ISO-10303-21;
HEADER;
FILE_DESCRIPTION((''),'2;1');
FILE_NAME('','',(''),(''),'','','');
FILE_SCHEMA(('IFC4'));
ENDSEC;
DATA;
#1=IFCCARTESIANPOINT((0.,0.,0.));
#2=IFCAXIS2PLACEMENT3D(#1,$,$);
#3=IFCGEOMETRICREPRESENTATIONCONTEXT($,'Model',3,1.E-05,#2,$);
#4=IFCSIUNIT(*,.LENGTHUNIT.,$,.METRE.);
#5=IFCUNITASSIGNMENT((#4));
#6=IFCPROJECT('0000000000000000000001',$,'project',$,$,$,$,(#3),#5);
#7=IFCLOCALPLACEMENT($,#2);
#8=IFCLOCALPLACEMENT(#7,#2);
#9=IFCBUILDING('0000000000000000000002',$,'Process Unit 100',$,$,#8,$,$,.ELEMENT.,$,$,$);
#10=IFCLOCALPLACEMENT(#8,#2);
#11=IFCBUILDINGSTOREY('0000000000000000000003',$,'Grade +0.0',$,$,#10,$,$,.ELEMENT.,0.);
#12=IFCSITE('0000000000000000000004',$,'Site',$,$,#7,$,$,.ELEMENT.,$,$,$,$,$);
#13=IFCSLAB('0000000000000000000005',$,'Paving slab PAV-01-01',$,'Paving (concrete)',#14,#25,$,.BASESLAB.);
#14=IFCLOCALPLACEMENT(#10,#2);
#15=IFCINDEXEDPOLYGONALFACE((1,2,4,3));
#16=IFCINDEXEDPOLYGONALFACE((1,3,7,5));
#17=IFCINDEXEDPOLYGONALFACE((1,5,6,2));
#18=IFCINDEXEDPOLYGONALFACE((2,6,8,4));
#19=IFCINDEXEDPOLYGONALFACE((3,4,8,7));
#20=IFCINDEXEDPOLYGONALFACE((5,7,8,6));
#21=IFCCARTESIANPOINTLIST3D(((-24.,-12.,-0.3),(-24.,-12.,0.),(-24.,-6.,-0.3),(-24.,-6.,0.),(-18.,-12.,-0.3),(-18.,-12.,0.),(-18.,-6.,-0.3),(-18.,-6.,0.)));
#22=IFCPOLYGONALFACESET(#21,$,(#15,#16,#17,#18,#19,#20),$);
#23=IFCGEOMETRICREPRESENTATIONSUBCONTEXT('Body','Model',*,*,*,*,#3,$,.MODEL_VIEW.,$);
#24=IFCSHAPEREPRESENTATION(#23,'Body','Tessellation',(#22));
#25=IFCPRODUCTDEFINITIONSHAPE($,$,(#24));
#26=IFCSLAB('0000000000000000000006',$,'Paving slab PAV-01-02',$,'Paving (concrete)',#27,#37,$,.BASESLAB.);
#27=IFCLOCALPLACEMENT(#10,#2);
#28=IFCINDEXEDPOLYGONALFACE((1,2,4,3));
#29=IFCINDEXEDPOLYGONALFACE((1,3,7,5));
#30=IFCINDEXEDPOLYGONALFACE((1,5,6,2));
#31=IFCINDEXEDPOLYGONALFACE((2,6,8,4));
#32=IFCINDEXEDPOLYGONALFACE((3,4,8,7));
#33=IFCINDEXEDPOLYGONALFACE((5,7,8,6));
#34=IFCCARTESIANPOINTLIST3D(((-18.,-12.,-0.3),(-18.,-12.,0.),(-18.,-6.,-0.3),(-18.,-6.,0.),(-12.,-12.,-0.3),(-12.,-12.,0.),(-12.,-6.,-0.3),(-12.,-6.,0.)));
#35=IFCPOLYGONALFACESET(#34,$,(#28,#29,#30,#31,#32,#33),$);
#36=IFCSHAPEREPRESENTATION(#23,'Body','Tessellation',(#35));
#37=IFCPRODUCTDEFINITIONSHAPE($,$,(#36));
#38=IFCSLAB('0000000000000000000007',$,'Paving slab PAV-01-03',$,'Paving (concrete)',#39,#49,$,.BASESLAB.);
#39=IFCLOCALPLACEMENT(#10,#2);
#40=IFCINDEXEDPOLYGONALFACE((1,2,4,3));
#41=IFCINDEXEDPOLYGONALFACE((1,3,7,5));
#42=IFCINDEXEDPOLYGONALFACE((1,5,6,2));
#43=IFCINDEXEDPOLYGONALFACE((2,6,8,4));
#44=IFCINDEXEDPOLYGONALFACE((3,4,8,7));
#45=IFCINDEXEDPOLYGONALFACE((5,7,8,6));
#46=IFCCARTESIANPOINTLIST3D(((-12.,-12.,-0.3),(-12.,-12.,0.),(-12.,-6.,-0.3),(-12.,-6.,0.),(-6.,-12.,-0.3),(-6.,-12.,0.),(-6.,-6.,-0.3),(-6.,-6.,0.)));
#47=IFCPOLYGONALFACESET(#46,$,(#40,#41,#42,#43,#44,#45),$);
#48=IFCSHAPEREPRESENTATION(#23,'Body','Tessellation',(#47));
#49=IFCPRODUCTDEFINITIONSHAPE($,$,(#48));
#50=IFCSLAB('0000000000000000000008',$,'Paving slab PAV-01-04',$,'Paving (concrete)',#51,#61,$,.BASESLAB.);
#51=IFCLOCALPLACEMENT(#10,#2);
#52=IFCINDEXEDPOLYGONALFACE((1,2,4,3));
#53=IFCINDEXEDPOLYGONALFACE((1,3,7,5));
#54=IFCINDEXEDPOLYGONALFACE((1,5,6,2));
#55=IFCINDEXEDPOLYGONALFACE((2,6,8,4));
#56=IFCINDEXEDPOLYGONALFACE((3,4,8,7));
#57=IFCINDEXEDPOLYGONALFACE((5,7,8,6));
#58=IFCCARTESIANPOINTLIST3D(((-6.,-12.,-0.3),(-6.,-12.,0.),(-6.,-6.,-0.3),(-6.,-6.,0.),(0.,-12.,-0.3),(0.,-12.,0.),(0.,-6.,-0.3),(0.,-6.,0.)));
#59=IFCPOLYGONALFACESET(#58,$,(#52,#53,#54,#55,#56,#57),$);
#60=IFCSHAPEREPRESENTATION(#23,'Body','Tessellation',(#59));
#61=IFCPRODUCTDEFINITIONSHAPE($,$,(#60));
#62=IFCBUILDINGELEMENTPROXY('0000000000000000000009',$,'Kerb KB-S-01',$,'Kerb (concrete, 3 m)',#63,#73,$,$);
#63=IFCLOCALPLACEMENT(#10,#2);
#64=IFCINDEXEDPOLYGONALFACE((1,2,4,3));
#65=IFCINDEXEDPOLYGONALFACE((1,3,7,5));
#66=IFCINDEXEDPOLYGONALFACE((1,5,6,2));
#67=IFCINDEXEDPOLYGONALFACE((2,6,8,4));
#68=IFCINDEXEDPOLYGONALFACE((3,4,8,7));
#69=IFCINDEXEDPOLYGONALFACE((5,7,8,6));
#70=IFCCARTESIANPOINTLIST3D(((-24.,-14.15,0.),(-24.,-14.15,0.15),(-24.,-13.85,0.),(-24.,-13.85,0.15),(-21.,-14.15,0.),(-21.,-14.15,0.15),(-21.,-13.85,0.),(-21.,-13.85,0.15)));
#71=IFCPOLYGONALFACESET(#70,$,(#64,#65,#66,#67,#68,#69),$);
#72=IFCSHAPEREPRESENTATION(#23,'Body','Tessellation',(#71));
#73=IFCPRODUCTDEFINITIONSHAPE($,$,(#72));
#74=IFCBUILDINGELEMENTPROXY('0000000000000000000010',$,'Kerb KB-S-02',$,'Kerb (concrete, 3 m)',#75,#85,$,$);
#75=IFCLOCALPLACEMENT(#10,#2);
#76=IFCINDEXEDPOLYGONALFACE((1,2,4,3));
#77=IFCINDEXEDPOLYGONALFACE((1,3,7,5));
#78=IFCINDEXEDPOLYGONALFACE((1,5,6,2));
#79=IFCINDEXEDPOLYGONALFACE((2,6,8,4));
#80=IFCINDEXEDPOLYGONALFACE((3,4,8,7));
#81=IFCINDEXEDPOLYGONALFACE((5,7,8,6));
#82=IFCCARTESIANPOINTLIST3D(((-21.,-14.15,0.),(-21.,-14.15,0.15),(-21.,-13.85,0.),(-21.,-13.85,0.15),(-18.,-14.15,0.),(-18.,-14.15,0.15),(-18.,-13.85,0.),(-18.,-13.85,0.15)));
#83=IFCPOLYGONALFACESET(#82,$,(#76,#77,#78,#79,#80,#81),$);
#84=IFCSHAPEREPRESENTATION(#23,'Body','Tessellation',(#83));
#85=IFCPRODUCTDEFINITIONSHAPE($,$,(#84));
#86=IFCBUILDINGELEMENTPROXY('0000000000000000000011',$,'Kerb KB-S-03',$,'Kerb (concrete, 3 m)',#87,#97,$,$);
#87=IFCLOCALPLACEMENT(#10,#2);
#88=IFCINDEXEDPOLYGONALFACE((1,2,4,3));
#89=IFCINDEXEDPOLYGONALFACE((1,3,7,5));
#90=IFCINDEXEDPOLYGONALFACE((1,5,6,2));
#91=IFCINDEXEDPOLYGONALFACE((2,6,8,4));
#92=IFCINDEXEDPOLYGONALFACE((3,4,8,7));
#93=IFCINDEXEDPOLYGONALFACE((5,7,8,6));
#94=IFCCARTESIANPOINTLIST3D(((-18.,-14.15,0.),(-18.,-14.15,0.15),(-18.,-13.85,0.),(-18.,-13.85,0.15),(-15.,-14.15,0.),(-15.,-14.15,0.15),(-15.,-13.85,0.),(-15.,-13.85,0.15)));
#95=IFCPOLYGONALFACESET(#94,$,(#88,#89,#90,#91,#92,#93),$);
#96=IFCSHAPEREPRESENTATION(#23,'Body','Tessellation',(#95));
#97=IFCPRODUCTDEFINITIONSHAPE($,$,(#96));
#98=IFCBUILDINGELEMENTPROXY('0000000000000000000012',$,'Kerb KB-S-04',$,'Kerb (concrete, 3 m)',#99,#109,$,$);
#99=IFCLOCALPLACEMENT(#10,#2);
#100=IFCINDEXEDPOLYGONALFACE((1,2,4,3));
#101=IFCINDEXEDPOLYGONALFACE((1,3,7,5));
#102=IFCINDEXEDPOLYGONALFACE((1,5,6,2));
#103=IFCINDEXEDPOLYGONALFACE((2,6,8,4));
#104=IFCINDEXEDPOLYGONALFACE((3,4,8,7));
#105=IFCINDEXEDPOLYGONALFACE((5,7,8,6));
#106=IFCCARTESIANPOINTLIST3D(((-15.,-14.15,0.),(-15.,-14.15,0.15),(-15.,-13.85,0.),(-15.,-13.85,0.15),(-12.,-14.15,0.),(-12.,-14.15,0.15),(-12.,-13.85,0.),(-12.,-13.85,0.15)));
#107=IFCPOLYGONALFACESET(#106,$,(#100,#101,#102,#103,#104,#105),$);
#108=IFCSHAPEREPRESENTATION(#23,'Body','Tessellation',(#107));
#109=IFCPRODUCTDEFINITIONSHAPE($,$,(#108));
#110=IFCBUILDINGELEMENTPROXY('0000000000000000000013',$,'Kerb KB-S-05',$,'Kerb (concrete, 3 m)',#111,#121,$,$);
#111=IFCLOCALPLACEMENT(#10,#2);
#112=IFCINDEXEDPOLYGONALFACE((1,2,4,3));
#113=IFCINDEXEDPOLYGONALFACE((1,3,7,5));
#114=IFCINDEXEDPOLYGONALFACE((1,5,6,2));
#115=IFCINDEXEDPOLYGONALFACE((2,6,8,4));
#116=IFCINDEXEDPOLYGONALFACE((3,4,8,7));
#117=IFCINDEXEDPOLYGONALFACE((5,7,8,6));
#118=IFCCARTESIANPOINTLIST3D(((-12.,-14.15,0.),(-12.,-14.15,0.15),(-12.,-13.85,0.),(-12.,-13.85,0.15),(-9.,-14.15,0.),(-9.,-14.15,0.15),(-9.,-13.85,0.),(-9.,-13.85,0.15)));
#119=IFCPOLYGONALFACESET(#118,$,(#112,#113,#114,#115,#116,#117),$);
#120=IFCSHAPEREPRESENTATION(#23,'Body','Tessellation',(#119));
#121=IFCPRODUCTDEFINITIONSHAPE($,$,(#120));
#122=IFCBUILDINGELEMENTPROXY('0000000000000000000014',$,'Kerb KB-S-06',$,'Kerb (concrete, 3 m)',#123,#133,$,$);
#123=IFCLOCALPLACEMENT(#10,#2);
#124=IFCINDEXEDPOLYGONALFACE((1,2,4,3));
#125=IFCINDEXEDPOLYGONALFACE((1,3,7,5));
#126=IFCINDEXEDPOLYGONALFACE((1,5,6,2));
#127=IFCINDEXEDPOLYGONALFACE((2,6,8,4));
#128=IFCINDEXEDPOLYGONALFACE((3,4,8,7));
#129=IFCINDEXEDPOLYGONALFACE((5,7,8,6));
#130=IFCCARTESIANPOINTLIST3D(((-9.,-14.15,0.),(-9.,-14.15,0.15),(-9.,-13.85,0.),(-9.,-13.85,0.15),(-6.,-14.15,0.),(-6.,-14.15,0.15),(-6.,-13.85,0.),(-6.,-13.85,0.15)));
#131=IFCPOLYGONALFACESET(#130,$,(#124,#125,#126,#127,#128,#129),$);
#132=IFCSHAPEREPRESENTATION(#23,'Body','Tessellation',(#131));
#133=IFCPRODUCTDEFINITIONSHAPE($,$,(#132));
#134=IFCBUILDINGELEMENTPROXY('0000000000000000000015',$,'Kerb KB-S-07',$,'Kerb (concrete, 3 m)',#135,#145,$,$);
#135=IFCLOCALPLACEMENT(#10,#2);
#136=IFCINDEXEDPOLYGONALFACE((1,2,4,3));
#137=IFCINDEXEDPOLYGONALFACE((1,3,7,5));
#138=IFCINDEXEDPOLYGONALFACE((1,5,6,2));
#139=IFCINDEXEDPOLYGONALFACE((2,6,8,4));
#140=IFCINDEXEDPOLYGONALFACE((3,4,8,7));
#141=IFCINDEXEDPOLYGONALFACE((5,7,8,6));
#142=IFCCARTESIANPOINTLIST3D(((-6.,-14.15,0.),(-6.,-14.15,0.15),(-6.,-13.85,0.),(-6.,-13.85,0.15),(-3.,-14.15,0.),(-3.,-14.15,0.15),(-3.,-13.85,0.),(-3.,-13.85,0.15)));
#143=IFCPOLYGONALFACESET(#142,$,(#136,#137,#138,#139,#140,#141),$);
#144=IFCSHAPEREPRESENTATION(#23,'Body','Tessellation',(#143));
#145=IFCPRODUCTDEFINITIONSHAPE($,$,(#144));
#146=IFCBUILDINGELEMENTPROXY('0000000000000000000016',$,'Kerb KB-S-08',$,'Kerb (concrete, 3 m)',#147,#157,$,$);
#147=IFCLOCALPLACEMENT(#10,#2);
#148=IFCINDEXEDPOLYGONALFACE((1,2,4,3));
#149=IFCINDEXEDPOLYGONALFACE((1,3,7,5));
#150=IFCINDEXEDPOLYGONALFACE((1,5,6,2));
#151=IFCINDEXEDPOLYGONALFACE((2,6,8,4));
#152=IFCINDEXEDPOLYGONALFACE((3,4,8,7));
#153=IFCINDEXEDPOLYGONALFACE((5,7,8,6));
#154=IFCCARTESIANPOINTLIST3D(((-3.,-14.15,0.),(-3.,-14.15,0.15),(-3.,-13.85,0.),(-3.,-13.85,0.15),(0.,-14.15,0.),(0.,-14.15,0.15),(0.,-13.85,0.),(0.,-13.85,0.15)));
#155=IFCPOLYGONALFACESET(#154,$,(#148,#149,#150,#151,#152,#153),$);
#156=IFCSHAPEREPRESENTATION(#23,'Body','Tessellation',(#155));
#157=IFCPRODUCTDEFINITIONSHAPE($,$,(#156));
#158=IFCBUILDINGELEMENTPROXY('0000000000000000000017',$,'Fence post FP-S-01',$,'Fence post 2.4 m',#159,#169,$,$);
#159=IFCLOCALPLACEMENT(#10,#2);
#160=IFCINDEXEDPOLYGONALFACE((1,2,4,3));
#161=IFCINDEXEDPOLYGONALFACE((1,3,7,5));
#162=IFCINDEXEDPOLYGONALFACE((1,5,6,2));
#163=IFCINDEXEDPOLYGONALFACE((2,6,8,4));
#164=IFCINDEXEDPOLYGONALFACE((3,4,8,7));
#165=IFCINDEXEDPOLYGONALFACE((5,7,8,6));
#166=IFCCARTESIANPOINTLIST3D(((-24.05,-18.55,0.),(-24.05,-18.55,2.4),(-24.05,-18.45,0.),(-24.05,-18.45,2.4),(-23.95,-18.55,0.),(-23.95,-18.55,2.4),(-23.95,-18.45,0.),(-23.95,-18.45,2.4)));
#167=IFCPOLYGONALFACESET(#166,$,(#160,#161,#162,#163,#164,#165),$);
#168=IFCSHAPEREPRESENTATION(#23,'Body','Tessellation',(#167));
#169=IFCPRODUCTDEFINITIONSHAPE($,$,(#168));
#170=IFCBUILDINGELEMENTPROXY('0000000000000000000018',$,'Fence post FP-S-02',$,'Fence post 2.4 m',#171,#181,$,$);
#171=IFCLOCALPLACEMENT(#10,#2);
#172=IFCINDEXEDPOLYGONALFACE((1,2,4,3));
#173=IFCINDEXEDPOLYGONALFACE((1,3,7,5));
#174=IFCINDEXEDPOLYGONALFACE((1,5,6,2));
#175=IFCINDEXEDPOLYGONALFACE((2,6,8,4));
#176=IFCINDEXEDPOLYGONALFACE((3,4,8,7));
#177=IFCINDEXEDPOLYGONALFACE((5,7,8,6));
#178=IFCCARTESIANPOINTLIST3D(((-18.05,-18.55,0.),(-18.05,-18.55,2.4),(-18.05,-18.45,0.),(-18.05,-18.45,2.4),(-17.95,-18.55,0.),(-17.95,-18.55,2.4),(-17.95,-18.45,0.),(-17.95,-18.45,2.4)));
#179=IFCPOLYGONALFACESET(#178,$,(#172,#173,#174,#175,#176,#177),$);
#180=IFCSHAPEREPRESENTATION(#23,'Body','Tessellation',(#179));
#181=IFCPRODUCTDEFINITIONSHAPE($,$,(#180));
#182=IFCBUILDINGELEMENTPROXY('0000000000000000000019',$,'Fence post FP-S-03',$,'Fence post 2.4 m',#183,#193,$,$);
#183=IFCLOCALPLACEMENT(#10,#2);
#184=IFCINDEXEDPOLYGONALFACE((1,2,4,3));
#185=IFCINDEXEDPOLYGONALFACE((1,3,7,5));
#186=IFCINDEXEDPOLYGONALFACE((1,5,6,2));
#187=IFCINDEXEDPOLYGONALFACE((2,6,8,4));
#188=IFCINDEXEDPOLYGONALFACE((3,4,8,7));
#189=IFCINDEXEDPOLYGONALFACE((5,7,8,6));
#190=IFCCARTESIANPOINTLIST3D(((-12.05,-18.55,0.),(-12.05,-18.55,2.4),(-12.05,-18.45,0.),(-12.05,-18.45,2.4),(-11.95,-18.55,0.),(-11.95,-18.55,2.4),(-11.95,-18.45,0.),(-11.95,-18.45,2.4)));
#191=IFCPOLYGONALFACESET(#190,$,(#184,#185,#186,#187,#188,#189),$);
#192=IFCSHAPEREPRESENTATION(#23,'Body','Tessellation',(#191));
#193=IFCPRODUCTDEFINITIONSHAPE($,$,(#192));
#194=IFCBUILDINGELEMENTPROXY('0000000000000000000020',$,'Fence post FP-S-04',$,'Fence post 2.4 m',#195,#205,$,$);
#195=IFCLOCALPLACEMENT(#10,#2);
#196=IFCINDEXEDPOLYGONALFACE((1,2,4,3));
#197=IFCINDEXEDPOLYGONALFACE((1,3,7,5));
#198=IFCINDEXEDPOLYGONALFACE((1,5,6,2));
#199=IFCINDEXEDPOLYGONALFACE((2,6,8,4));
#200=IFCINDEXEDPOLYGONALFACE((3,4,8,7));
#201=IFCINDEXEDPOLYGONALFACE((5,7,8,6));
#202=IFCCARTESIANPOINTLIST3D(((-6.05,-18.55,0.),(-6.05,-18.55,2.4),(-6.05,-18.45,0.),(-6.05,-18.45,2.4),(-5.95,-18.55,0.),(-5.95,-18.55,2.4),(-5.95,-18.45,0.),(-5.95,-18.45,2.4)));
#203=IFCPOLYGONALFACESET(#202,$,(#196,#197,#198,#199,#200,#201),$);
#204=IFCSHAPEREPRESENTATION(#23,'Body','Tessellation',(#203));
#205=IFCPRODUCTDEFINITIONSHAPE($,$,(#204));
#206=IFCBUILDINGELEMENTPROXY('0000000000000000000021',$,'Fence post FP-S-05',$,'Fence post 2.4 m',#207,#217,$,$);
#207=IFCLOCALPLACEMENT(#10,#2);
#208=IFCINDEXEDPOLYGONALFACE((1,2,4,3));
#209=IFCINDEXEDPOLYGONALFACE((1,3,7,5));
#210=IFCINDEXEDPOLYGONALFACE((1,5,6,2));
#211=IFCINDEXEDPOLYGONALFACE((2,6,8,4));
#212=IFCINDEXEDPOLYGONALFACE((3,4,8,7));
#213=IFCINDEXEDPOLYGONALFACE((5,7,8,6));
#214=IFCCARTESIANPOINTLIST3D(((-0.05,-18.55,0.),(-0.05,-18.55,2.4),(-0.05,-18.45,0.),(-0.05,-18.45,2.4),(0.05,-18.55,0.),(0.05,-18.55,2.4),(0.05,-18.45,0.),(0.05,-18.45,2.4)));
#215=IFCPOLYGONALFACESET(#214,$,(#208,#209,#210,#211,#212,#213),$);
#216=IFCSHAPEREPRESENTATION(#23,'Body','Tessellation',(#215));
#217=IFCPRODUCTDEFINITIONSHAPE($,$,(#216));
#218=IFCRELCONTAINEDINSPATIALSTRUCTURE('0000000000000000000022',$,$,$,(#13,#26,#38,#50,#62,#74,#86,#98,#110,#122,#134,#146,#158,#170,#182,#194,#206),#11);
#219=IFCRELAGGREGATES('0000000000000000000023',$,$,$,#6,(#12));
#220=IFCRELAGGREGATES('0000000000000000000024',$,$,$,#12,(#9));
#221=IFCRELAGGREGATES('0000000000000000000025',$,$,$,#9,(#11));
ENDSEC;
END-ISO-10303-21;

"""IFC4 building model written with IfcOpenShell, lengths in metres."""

from ifc_helpers import new_model, si_unit, frame, origin, place, context, subcontext, project, spatial, rectangle, extrude, element, save


model = new_model("IFC4")

# Units and contexts
model_context = context("Model", 3, precision=1e-05, world=origin())
body_context = subcontext(model_context, "Body", "Model", "MODEL_VIEW")
ifc_project = project(units=[si_unit("LENGTHUNIT", "METRE")], contexts=[model_context])

# Site, building, storey
site_placement = place(None, origin())
site = spatial("IfcSite", under=ifc_project, at=site_placement, Name="Site", CompositionType="ELEMENT")
building_placement = place(site_placement, origin())
building = spatial("IfcBuilding", under=site, at=building_placement, Name="Process Unit 100", CompositionType="ELEMENT")
storey_placement = place(building_placement, origin())
storey = spatial("IfcBuildingStorey", under=building, at=storey_placement, Name="Grade +0.0", CompositionType="ELEMENT", Elevation=0.0)

# Slabs
for number, where, z_axis, x_axis, name in (
    (1, (-21.0, -9.0, -0.3), (0.0, 0.0, 1.0), (1.0, 0.0, 0.0), "Paving slab PAV-01-01"),
    (2, (-15.0, -9.0, -0.3), (0.0, 0.0, 1.0), (1.0, 0.0, 0.0), "Paving slab PAV-01-02"),
    (3, (-9.0, -9.0, -0.3), (0.0, 0.0, 1.0), (1.0, 0.0, 0.0), "Paving slab PAV-01-03"),
    (4, (-3.0, -9.0, -0.3), (0.0, 0.0, 1.0), (1.0, 0.0, 0.0), "Paving slab PAV-01-04"),
):
    element("IfcSlab", number, at=place(storey_placement, frame(where, z_axis=z_axis, x_axis=x_axis)), inside=storey, Name=name, ObjectType="Paving (concrete)", PredefinedType="BASESLAB", context=body_context, shape_type="SweptSolid", body=[
        extrude(rectangle(XDim=6.0, YDim=6.0), origin(), (0.0, 0.0, 1.0), 0.3),
    ])

# Building element proxies
for number, where, z_axis, x_axis, name in (
    (5, (-22.5, -14.0, 0.0), (0.0, 0.0, 1.0), (1.0, 0.0, 0.0), "Kerb KB-S-01"),
    (6, (-19.5, -14.0, 0.0), (0.0, 0.0, 1.0), (1.0, 0.0, 0.0), "Kerb KB-S-02"),
    (7, (-16.5, -14.0, 0.0), (0.0, 0.0, 1.0), (1.0, 0.0, 0.0), "Kerb KB-S-03"),
    (8, (-13.5, -14.0, 0.0), (0.0, 0.0, 1.0), (1.0, 0.0, 0.0), "Kerb KB-S-04"),
    (9, (-10.5, -14.0, 0.0), (0.0, 0.0, 1.0), (1.0, 0.0, 0.0), "Kerb KB-S-05"),
    (10, (-7.5, -14.0, 0.0), (0.0, 0.0, 1.0), (1.0, 0.0, 0.0), "Kerb KB-S-06"),
    (11, (-4.5, -14.0, 0.0), (0.0, 0.0, 1.0), (1.0, 0.0, 0.0), "Kerb KB-S-07"),
    (12, (-1.5, -14.0, 0.0), (0.0, 0.0, 1.0), (1.0, 0.0, 0.0), "Kerb KB-S-08"),
):
    element("IfcBuildingElementProxy", number, at=place(storey_placement, frame(where, z_axis=z_axis, x_axis=x_axis)), inside=storey, Name=name, ObjectType="Kerb (concrete, 3 m)", context=body_context, shape_type="SweptSolid", body=[
        extrude(rectangle(XDim=3.0, YDim=0.3), origin(), (0.0, 0.0, 1.0), 0.15),
    ])
for number, where, z_axis, x_axis, name in (
    (13, (-24.0, -18.5, 0.0), (0.0, 0.0, 1.0), (1.0, 0.0, 0.0), "Fence post FP-S-01"),
    (14, (-18.0, -18.5, 0.0), (0.0, 0.0, 1.0), (1.0, 0.0, 0.0), "Fence post FP-S-02"),
    (15, (-12.0, -18.5, 0.0), (0.0, 0.0, 1.0), (1.0, 0.0, 0.0), "Fence post FP-S-03"),
    (16, (-6.0, -18.5, 0.0), (0.0, 0.0, 1.0), (1.0, 0.0, 0.0), "Fence post FP-S-04"),
    (17, (0.0, -18.5, 0.0), (0.0, 0.0, 1.0), (1.0, 0.0, 0.0), "Fence post FP-S-05"),
):
    element("IfcBuildingElementProxy", number, at=place(storey_placement, frame(where, z_axis=z_axis, x_axis=x_axis)), inside=storey, Name=name, ObjectType="Fence post 2.4 m", context=body_context, shape_type="SweptSolid", body=[
        extrude(rectangle(XDim=0.1, YDim=0.1), origin(), (0.0, 0.0, 1.0), 2.4),
    ])

save(model, "model.ifc")
